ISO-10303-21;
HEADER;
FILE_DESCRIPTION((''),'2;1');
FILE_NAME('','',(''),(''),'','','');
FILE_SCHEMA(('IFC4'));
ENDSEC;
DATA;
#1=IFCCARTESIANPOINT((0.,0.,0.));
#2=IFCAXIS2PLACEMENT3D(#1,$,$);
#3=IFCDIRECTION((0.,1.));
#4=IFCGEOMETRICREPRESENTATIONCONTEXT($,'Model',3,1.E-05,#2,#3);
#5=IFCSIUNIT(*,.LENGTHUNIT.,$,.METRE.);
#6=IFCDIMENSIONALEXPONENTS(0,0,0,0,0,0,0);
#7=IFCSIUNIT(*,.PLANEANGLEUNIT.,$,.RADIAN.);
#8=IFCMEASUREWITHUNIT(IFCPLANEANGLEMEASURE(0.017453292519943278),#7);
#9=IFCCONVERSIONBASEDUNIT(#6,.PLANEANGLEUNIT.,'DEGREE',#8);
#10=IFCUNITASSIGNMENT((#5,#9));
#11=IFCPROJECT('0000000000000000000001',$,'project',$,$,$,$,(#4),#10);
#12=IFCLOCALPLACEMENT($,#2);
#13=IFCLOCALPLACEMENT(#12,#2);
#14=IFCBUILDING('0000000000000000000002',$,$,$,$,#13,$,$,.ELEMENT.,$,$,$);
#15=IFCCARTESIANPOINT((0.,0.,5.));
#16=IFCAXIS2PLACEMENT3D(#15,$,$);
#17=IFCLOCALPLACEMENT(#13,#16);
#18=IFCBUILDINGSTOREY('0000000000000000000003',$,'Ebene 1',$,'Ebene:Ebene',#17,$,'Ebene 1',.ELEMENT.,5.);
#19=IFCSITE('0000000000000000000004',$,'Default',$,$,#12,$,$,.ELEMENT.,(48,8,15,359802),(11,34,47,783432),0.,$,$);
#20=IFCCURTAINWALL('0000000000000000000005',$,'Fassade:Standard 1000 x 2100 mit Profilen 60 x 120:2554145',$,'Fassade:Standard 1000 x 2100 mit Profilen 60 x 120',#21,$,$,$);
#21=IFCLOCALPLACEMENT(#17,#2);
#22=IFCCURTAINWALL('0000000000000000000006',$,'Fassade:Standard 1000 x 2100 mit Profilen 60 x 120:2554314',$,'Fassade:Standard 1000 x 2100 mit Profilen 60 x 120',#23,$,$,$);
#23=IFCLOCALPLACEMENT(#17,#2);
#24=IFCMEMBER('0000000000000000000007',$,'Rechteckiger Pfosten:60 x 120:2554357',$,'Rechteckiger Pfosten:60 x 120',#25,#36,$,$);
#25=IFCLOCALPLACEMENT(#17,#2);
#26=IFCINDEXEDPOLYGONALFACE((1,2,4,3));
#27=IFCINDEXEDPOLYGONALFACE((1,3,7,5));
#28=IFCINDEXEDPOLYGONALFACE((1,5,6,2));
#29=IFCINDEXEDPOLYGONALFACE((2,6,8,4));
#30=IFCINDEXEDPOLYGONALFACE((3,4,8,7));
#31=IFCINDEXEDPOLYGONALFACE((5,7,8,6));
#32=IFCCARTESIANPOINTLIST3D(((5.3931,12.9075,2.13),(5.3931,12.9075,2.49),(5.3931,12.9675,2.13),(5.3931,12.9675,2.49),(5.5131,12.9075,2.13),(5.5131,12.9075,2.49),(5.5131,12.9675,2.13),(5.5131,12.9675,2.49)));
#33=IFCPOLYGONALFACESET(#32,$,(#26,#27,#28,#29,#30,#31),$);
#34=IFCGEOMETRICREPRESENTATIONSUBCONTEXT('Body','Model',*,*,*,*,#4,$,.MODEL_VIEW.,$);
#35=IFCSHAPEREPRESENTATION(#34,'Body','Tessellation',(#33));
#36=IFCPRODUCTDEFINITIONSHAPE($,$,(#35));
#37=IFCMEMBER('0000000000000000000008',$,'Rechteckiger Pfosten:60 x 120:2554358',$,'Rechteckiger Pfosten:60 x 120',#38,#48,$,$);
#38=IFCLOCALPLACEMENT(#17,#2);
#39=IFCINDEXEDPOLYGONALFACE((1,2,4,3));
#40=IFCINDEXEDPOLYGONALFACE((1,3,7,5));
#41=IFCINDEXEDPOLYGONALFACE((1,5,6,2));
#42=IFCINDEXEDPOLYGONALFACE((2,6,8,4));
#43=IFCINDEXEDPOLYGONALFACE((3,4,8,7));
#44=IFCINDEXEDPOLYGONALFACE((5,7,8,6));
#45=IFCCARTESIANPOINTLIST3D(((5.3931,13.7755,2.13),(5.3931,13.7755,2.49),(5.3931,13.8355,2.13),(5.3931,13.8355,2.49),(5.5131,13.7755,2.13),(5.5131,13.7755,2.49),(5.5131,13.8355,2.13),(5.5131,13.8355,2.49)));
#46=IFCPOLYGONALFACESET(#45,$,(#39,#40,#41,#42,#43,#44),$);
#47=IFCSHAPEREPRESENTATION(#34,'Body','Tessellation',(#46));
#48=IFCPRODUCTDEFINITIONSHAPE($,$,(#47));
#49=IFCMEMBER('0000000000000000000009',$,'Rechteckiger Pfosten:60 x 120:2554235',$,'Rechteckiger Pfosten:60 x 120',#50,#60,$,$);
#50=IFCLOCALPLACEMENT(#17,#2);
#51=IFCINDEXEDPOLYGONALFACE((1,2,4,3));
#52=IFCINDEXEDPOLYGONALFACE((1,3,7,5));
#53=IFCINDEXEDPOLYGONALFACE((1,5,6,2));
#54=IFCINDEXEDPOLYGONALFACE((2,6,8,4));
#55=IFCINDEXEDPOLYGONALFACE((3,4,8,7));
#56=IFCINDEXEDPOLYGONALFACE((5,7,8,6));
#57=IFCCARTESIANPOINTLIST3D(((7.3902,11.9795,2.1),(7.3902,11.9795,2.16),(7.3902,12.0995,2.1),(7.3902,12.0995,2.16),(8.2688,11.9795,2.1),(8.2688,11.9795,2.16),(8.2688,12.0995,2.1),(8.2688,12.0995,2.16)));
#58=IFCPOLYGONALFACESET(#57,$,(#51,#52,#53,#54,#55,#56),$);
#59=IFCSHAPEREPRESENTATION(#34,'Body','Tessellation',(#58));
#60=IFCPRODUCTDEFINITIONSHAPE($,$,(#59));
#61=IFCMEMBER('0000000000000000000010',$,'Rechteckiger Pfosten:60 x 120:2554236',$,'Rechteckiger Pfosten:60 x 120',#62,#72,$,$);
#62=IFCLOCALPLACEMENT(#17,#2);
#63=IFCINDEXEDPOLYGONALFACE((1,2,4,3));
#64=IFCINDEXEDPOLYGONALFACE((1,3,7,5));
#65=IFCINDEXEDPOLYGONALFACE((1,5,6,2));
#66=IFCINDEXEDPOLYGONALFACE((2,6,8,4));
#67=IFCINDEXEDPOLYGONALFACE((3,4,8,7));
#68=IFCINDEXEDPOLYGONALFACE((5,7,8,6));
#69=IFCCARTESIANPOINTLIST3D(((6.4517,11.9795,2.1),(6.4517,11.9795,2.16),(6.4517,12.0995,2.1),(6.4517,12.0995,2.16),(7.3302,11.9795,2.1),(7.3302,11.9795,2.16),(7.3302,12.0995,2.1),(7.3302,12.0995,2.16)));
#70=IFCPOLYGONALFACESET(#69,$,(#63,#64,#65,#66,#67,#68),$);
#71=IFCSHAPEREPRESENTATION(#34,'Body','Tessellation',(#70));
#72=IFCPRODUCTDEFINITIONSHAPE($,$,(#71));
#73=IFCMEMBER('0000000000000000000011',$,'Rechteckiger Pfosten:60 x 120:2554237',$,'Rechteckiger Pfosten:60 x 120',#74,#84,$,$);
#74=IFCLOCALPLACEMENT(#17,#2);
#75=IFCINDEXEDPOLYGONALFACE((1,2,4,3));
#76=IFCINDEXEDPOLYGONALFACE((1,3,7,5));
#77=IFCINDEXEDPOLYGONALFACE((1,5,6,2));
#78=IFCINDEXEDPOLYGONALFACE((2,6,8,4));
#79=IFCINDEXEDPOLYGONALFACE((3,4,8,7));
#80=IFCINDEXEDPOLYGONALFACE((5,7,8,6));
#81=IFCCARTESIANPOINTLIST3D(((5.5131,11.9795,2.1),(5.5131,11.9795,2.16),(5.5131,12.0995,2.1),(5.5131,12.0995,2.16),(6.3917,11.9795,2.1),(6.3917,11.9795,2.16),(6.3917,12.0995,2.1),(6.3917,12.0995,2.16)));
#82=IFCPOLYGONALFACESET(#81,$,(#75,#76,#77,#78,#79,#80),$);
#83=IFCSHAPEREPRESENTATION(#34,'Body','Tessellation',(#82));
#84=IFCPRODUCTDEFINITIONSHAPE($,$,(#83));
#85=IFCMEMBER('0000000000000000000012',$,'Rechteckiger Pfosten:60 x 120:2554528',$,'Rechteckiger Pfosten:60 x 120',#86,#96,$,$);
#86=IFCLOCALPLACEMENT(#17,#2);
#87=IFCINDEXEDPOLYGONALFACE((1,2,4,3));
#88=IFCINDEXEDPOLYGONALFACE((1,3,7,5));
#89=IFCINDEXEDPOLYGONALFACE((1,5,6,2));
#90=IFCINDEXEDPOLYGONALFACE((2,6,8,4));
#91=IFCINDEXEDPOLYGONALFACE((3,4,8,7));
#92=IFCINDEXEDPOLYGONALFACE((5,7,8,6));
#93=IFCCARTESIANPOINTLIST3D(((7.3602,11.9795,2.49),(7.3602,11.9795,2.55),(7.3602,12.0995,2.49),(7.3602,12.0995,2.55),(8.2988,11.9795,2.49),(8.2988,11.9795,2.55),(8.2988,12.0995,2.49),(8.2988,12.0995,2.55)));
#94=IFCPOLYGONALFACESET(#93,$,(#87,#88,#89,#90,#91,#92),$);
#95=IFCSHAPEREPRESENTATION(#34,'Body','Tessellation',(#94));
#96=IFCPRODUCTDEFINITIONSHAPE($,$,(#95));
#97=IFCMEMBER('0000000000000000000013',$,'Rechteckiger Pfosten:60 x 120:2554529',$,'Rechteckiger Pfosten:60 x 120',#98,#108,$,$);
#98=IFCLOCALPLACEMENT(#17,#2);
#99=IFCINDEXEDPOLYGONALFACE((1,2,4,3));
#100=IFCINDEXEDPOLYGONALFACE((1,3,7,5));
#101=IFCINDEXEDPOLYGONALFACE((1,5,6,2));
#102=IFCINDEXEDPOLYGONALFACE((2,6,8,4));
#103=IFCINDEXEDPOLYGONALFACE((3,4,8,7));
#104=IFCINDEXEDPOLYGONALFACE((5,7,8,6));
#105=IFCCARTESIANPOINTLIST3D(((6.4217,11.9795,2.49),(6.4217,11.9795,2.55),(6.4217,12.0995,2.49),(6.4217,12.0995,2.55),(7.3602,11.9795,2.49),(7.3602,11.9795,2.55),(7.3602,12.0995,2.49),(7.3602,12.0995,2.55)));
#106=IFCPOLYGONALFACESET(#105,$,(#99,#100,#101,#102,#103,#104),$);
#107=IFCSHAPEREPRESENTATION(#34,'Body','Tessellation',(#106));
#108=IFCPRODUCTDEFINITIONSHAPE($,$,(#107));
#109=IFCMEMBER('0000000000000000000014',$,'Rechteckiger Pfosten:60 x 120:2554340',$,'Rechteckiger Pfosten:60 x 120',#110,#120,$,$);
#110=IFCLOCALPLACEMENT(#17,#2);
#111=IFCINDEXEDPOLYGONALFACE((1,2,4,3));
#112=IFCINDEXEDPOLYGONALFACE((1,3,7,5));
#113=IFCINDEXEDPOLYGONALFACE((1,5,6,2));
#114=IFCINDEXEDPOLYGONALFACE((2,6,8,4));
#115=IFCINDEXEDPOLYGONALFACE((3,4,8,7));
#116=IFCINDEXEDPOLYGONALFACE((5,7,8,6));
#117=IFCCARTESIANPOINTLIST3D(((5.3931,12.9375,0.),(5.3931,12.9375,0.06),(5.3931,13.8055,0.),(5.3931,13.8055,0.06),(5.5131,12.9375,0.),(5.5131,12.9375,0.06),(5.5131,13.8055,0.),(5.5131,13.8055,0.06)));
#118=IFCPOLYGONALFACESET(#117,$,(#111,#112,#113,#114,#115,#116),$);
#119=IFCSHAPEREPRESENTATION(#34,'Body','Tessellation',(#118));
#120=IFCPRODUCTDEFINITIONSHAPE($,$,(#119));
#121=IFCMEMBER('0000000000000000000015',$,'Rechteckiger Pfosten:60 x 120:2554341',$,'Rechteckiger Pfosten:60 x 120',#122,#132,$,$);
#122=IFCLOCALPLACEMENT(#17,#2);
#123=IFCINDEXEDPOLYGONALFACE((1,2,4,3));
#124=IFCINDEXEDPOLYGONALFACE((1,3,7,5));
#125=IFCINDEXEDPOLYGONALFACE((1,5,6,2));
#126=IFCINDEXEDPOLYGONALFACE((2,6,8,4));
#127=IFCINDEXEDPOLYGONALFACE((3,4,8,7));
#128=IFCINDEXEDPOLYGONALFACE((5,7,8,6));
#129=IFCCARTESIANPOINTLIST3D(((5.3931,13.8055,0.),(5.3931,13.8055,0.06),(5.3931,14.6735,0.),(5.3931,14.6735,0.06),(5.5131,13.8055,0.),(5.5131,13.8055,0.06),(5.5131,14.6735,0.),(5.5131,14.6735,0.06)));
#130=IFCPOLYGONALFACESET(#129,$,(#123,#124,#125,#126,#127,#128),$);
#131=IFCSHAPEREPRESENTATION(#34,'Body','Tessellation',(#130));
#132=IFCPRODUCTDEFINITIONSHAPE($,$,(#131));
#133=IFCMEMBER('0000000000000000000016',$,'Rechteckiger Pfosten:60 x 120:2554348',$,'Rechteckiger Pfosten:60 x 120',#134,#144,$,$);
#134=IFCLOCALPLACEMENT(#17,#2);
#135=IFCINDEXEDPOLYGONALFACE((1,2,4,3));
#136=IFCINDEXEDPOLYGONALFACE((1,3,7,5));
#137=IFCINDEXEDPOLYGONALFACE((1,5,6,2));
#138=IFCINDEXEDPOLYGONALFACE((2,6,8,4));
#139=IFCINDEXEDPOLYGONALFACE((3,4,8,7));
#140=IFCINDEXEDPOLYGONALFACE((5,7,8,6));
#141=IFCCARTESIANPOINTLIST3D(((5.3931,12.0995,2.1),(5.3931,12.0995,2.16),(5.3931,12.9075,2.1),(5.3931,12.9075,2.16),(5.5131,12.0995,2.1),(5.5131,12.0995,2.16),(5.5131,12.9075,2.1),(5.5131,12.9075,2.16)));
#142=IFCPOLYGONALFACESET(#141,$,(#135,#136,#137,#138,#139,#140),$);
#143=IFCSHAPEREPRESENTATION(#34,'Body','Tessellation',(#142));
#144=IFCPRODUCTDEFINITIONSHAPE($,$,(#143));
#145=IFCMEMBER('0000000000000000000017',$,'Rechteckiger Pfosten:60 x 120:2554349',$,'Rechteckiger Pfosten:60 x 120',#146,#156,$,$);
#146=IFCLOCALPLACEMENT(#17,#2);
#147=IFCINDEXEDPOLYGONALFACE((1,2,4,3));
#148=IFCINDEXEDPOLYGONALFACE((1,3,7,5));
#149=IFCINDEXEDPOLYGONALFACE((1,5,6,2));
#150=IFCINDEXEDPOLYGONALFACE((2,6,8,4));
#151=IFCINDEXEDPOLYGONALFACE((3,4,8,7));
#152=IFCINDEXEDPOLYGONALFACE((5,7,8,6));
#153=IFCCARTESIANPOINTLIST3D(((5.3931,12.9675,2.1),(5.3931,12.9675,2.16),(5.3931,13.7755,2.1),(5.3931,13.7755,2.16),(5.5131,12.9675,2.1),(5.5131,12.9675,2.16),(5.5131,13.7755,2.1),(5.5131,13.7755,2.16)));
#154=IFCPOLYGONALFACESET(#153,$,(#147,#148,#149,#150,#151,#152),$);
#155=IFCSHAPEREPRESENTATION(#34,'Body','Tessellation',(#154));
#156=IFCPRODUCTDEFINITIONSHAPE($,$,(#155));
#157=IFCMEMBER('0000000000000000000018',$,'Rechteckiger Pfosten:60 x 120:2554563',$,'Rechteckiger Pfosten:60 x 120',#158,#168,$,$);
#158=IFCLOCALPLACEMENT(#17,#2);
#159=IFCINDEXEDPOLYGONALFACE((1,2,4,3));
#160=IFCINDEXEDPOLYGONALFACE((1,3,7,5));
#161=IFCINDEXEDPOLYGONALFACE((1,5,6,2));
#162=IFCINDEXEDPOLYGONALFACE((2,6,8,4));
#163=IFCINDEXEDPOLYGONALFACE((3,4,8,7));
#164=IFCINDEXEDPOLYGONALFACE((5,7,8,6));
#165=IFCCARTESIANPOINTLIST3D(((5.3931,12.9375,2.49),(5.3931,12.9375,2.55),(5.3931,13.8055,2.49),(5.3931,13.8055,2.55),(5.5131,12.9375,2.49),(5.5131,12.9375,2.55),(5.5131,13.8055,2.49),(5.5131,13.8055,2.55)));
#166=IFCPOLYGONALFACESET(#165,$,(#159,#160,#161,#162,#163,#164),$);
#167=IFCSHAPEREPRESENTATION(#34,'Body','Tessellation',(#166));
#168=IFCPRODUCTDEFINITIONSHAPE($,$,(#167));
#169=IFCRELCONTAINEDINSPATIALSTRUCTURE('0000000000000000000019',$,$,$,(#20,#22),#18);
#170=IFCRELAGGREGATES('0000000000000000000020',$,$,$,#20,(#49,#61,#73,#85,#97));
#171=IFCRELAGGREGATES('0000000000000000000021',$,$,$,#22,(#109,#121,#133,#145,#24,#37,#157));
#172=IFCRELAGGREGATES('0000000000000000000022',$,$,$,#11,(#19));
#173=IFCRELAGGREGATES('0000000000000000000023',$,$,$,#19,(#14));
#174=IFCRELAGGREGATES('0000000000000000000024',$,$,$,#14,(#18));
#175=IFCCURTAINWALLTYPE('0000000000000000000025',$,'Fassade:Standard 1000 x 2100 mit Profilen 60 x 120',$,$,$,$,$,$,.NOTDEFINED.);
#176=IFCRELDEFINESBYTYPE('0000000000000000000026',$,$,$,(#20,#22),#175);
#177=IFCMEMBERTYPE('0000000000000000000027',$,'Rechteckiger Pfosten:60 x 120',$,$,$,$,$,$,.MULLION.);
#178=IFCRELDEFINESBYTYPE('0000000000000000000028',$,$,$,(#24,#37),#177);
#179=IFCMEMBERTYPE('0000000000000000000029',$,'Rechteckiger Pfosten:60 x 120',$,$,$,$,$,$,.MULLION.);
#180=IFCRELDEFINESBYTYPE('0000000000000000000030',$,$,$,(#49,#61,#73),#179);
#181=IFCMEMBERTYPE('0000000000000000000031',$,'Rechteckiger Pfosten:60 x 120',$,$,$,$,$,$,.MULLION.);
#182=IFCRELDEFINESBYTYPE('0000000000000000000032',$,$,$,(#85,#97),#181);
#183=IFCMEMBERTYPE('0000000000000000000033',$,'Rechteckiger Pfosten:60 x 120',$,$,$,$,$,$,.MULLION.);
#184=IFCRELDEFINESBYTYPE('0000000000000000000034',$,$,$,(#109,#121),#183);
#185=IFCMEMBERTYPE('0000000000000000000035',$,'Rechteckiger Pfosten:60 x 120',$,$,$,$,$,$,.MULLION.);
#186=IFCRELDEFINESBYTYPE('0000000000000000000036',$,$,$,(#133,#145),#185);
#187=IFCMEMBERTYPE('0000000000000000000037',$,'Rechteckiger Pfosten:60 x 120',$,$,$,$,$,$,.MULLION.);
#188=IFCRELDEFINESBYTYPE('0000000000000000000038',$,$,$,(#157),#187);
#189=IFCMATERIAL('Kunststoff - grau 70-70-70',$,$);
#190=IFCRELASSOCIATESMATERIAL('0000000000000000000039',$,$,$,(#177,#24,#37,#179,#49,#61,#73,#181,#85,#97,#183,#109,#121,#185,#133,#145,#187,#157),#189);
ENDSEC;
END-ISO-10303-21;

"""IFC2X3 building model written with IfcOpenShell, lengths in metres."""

from ifc_helpers import new_model, entity, si_unit, converted_unit, direction, frame, frame_2d, origin, origin_2d_with_axis, place, context, subcontext, project, spatial, rectangle, extrude, source, transform, mapped, material, type_object, type_shapes, element, aggregate, save


model = new_model("IFC2X3")

# Units and contexts
model_context = context("Model", 3, precision=1e-05, world=origin(), true_north=direction((0.0, 1.0)))
body_context = subcontext(model_context, "Body", "Model", "MODEL_VIEW")
ifc_project = project(units=[si_unit("LENGTHUNIT", "METRE"), converted_unit("PLANEANGLEUNIT", "DEGREE", entity("IfcPlaneAngleMeasure", 0.017453292519943278), si_unit("PLANEANGLEUNIT", "RADIAN"), dimensions=[0, 0, 0, 0, 0, 0, 0])], contexts=[model_context])

# Site, building, storey
site_placement = place(None, origin())
site = spatial("IfcSite", under=ifc_project, at=site_placement, Name="Default", CompositionType="ELEMENT", RefLatitude=(48, 8, 15, 359802), RefLongitude=(11, 34, 47, 783432), RefElevation=0.0)
building_placement = place(site_placement, origin())
building = spatial("IfcBuilding", under=site, at=building_placement, CompositionType="ELEMENT")
storey_placement = place(building_placement, frame((0.0, 0.0, 5.0)))
storey = spatial("IfcBuildingStorey", under=building, at=storey_placement, Name="Ebene 1", ObjectType="Ebene:Ebene", LongName="Ebene 1", CompositionType="ELEMENT", Elevation=5.0)

# Curtain walls
curtain_wall_type = type_object("IfcCurtainWallType", Name="Fassade:Standard 1000 x 2100 mit Profilen 60 x 120", PredefinedType="NOTDEFINED")
curtain_wall_1_placement = place(storey_placement, frame((0.0, 0.0, -5.0)))
curtain_wall_1 = element("IfcCurtainWall", 1, at=curtain_wall_1_placement, inside=storey, type_object=curtain_wall_type, Name="Fassade:Standard 1000 x 2100 mit Profilen 60 x 120:2554145", ObjectType="Fassade:Standard 1000 x 2100 mit Profilen 60 x 120")
ifc_material_1 = material(Name="Kunststoff - grau 70-70-70")
curtain_wall_2_placement = place(storey_placement, frame((0.0, 0.0, -5.0)))
curtain_wall_2 = element("IfcCurtainWall", 2, at=curtain_wall_2_placement, inside=storey, type_object=curtain_wall_type, Name="Fassade:Standard 1000 x 2100 mit Profilen 60 x 120:2554314", ObjectType="Fassade:Standard 1000 x 2100 mit Profilen 60 x 120")

# Members
member_type_1 = type_object("IfcMemberType", Name="Rechteckiger Pfosten:60 x 120", PredefinedType="MULLION", material=ifc_material_1)
shared_shape_1 = source(origin(), body_context, "Body", "SweptSolid", [
    extrude(rectangle(XDim=0.06, YDim=0.12, at=frame_2d((0.0, 0.0), x_axis=(1.0, 0.0))), frame((0.0, 0.0, -0.36), z_axis=(0.0, 0.0, 1.0), x_axis=(-1.0, 0.0, 0.0)), (0.0, 0.0, 1.0), 0.36),
])
type_shapes(member_type_1, [shared_shape_1])
member_1_placement = place(curtain_wall_2_placement, frame((5.4531, 12.9375, 7.13), z_axis=(0.0, 0.0, -1.0), x_axis=(0.0, 1.0, 0.0)))
member_1 = element("IfcMember", 3, at=member_1_placement, type_object=member_type_1, material=ifc_material_1, Name="Rechteckiger Pfosten:60 x 120:2554357", ObjectType="Rechteckiger Pfosten:60 x 120", context=body_context, shape_type="MappedRepresentation", body=[
    mapped(shared_shape_1, transform((0.0, 0.0, 0.0), scale=1.0)),
])
member_2_placement = place(curtain_wall_2_placement, frame((5.4531, 13.8055, 7.13), z_axis=(0.0, 0.0, -1.0), x_axis=(0.0, 1.0, 0.0)))
member_2 = element("IfcMember", 4, at=member_2_placement, type_object=member_type_1, material=ifc_material_1, Name="Rechteckiger Pfosten:60 x 120:2554358", ObjectType="Rechteckiger Pfosten:60 x 120", context=body_context, shape_type="MappedRepresentation", body=[
    mapped(shared_shape_1, transform((0.0, 0.0, 0.0), scale=1.0)),
])
member_type_2 = type_object("IfcMemberType", Name="Rechteckiger Pfosten:60 x 120", PredefinedType="MULLION", material=ifc_material_1)
shared_shape_2 = source(origin(), body_context, "Body", "SweptSolid", [
    extrude(rectangle(XDim=0.06, YDim=0.12, at=frame_2d((0.0, 0.0), x_axis=(1.0, 0.0))), frame((0.0, 0.0, -0.8786), z_axis=(0.0, 0.0, 1.0), x_axis=(-1.0, 0.0, 0.0)), (0.0, 0.0, 1.0), 0.8786),
])
type_shapes(member_type_2, [shared_shape_2])
member_3_placement = place(curtain_wall_1_placement, frame((7.3902, 12.0395, 7.13), z_axis=(-1.0, 0.0, 0.0), x_axis=(0.0, 0.0, 1.0)))
member_3 = element("IfcMember", 5, at=member_3_placement, type_object=member_type_2, material=ifc_material_1, Name="Rechteckiger Pfosten:60 x 120:2554235", ObjectType="Rechteckiger Pfosten:60 x 120", context=body_context, shape_type="MappedRepresentation", body=[
    mapped(shared_shape_2, transform((0.0, 0.0, 0.0), scale=1.0)),
])
member_4_placement = place(curtain_wall_1_placement, frame((6.4517, 12.0395, 7.13), z_axis=(-1.0, 0.0, 0.0), x_axis=(0.0, 0.0, 1.0)))
member_4 = element("IfcMember", 6, at=member_4_placement, type_object=member_type_2, material=ifc_material_1, Name="Rechteckiger Pfosten:60 x 120:2554236", ObjectType="Rechteckiger Pfosten:60 x 120", context=body_context, shape_type="MappedRepresentation", body=[
    mapped(shared_shape_2, transform((0.0, 0.0, 0.0), scale=1.0)),
])
member_5_placement = place(curtain_wall_1_placement, frame((5.5131, 12.0395, 7.13), z_axis=(-1.0, 0.0, 0.0), x_axis=(0.0, 0.0, 1.0)))
member_5 = element("IfcMember", 7, at=member_5_placement, type_object=member_type_2, material=ifc_material_1, Name="Rechteckiger Pfosten:60 x 120:2554237", ObjectType="Rechteckiger Pfosten:60 x 120", context=body_context, shape_type="MappedRepresentation", body=[
    mapped(shared_shape_2, transform((0.0, 0.0, 0.0), scale=1.0)),
])
member_type_3 = type_object("IfcMemberType", Name="Rechteckiger Pfosten:60 x 120", PredefinedType="MULLION", material=ifc_material_1)
shared_shape_3 = source(origin(), body_context, "Body", "SweptSolid", [
    extrude(rectangle(XDim=0.06, YDim=0.12, at=origin_2d_with_axis()), frame((-0.03, 0.0, -0.9386), z_axis=(0.0, 0.0, 1.0), x_axis=(-1.0, 0.0, 0.0)), (0.0, 0.0, 1.0), 0.9386),
])
type_shapes(member_type_3, [shared_shape_3])
member_6_placement = place(curtain_wall_1_placement, frame((7.3602, 12.0395, 7.55), z_axis=(-1.0, 0.0, 0.0), x_axis=(0.0, 0.0, 1.0)))
member_6 = element("IfcMember", 8, at=member_6_placement, type_object=member_type_3, material=ifc_material_1, Name="Rechteckiger Pfosten:60 x 120:2554528", ObjectType="Rechteckiger Pfosten:60 x 120", context=body_context, shape_type="MappedRepresentation", body=[
    mapped(shared_shape_3, transform((0.0, 0.0, 0.0), scale=1.0)),
])
member_7_placement = place(curtain_wall_1_placement, frame((6.4217, 12.0395, 7.55), z_axis=(-1.0, 0.0, 0.0), x_axis=(0.0, 0.0, 1.0)))
member_7 = element("IfcMember", 9, at=member_7_placement, type_object=member_type_3, material=ifc_material_1, Name="Rechteckiger Pfosten:60 x 120:2554529", ObjectType="Rechteckiger Pfosten:60 x 120", context=body_context, shape_type="MappedRepresentation", body=[
    mapped(shared_shape_3, transform((0.0, 0.0, 0.0), scale=1.0)),
])
member_type_4 = type_object("IfcMemberType", Name="Rechteckiger Pfosten:60 x 120", PredefinedType="MULLION", material=ifc_material_1)
shared_shape_4 = source(origin(), body_context, "Body", "SweptSolid", [
    extrude(rectangle(XDim=0.06, YDim=0.12, at=origin_2d_with_axis()), frame((-0.03, 0.0, -0.868), z_axis=(0.0, 0.0, 1.0), x_axis=(-1.0, 0.0, 0.0)), (0.0, 0.0, 1.0), 0.868),
])
type_shapes(member_type_4, [shared_shape_4])
member_8_placement = place(curtain_wall_2_placement, frame((5.4531, 12.9375, 5.0), z_axis=(0.0, -1.0, 0.0), x_axis=(0.0, 0.0, -1.0)))
member_8 = element("IfcMember", 10, at=member_8_placement, type_object=member_type_4, material=ifc_material_1, Name="Rechteckiger Pfosten:60 x 120:2554340", ObjectType="Rechteckiger Pfosten:60 x 120", context=body_context, shape_type="MappedRepresentation", body=[
    mapped(shared_shape_4, transform((0.0, 0.0, 0.0), scale=1.0)),
])
member_9_placement = place(curtain_wall_2_placement, frame((5.4531, 13.8055, 5.0), z_axis=(0.0, -1.0, 0.0), x_axis=(0.0, 0.0, -1.0)))
member_9 = element("IfcMember", 11, at=member_9_placement, type_object=member_type_4, material=ifc_material_1, Name="Rechteckiger Pfosten:60 x 120:2554341", ObjectType="Rechteckiger Pfosten:60 x 120", context=body_context, shape_type="MappedRepresentation", body=[
    mapped(shared_shape_4, transform((0.0, 0.0, 0.0), scale=1.0)),
])
member_type_5 = type_object("IfcMemberType", Name="Rechteckiger Pfosten:60 x 120", PredefinedType="MULLION", material=ifc_material_1)
shared_shape_5 = source(origin(), body_context, "Body", "SweptSolid", [
    extrude(rectangle(XDim=0.06, YDim=0.12, at=origin_2d_with_axis()), frame((0.0, 0.0, -0.808), z_axis=(0.0, 0.0, 1.0), x_axis=(-1.0, 0.0, 0.0)), (0.0, 0.0, 1.0), 0.808),
])
type_shapes(member_type_5, [shared_shape_5])
member_10_placement = place(curtain_wall_2_placement, frame((5.4531, 12.9075, 7.13), z_axis=(0.0, 1.0, 0.0), x_axis=(0.0, 0.0, 1.0)))
member_10 = element("IfcMember", 12, at=member_10_placement, type_object=member_type_5, material=ifc_material_1, Name="Rechteckiger Pfosten:60 x 120:2554348", ObjectType="Rechteckiger Pfosten:60 x 120", context=body_context, shape_type="MappedRepresentation", body=[
    mapped(shared_shape_5, transform((0.0, 0.0, 0.0), scale=1.0)),
])
member_11_placement = place(curtain_wall_2_placement, frame((5.4531, 13.7755, 7.13), z_axis=(0.0, 1.0, 0.0), x_axis=(0.0, 0.0, 1.0)))
member_11 = element("IfcMember", 13, at=member_11_placement, type_object=member_type_5, material=ifc_material_1, Name="Rechteckiger Pfosten:60 x 120:2554349", ObjectType="Rechteckiger Pfosten:60 x 120", context=body_context, shape_type="MappedRepresentation", body=[
    mapped(shared_shape_5, transform((0.0, 0.0, 0.0), scale=1.0)),
])
member_type_6 = type_object("IfcMemberType", Name="Rechteckiger Pfosten:60 x 120", PredefinedType="MULLION", material=ifc_material_1)
shared_shape_6 = source(origin(), body_context, "Body", "SweptSolid", [
    extrude(rectangle(XDim=0.06, YDim=0.12, at=origin_2d_with_axis()), frame((-0.03, 0.0, -0.868), z_axis=(0.0, 0.0, 1.0), x_axis=(-1.0, 0.0, 0.0)), (0.0, 0.0, 1.0), 0.868),
])
type_shapes(member_type_6, [shared_shape_6])
member_12_placement = place(curtain_wall_2_placement, frame((5.4531, 13.8055, 7.55), z_axis=(0.0, 1.0, 0.0), x_axis=(0.0, 0.0, 1.0)))
member_12 = element("IfcMember", 14, at=member_12_placement, type_object=member_type_6, material=ifc_material_1, Name="Rechteckiger Pfosten:60 x 120:2554563", ObjectType="Rechteckiger Pfosten:60 x 120", context=body_context, shape_type="MappedRepresentation", body=[
    mapped(shared_shape_6, transform((0.0, 0.0, 0.0), scale=1.0)),
])

aggregate(curtain_wall_1, [member_3, member_4, member_5, member_6, member_7])
aggregate(curtain_wall_2, [member_8, member_9, member_10, member_11, member_1, member_2, member_12])

save(model, "model.ifc")
